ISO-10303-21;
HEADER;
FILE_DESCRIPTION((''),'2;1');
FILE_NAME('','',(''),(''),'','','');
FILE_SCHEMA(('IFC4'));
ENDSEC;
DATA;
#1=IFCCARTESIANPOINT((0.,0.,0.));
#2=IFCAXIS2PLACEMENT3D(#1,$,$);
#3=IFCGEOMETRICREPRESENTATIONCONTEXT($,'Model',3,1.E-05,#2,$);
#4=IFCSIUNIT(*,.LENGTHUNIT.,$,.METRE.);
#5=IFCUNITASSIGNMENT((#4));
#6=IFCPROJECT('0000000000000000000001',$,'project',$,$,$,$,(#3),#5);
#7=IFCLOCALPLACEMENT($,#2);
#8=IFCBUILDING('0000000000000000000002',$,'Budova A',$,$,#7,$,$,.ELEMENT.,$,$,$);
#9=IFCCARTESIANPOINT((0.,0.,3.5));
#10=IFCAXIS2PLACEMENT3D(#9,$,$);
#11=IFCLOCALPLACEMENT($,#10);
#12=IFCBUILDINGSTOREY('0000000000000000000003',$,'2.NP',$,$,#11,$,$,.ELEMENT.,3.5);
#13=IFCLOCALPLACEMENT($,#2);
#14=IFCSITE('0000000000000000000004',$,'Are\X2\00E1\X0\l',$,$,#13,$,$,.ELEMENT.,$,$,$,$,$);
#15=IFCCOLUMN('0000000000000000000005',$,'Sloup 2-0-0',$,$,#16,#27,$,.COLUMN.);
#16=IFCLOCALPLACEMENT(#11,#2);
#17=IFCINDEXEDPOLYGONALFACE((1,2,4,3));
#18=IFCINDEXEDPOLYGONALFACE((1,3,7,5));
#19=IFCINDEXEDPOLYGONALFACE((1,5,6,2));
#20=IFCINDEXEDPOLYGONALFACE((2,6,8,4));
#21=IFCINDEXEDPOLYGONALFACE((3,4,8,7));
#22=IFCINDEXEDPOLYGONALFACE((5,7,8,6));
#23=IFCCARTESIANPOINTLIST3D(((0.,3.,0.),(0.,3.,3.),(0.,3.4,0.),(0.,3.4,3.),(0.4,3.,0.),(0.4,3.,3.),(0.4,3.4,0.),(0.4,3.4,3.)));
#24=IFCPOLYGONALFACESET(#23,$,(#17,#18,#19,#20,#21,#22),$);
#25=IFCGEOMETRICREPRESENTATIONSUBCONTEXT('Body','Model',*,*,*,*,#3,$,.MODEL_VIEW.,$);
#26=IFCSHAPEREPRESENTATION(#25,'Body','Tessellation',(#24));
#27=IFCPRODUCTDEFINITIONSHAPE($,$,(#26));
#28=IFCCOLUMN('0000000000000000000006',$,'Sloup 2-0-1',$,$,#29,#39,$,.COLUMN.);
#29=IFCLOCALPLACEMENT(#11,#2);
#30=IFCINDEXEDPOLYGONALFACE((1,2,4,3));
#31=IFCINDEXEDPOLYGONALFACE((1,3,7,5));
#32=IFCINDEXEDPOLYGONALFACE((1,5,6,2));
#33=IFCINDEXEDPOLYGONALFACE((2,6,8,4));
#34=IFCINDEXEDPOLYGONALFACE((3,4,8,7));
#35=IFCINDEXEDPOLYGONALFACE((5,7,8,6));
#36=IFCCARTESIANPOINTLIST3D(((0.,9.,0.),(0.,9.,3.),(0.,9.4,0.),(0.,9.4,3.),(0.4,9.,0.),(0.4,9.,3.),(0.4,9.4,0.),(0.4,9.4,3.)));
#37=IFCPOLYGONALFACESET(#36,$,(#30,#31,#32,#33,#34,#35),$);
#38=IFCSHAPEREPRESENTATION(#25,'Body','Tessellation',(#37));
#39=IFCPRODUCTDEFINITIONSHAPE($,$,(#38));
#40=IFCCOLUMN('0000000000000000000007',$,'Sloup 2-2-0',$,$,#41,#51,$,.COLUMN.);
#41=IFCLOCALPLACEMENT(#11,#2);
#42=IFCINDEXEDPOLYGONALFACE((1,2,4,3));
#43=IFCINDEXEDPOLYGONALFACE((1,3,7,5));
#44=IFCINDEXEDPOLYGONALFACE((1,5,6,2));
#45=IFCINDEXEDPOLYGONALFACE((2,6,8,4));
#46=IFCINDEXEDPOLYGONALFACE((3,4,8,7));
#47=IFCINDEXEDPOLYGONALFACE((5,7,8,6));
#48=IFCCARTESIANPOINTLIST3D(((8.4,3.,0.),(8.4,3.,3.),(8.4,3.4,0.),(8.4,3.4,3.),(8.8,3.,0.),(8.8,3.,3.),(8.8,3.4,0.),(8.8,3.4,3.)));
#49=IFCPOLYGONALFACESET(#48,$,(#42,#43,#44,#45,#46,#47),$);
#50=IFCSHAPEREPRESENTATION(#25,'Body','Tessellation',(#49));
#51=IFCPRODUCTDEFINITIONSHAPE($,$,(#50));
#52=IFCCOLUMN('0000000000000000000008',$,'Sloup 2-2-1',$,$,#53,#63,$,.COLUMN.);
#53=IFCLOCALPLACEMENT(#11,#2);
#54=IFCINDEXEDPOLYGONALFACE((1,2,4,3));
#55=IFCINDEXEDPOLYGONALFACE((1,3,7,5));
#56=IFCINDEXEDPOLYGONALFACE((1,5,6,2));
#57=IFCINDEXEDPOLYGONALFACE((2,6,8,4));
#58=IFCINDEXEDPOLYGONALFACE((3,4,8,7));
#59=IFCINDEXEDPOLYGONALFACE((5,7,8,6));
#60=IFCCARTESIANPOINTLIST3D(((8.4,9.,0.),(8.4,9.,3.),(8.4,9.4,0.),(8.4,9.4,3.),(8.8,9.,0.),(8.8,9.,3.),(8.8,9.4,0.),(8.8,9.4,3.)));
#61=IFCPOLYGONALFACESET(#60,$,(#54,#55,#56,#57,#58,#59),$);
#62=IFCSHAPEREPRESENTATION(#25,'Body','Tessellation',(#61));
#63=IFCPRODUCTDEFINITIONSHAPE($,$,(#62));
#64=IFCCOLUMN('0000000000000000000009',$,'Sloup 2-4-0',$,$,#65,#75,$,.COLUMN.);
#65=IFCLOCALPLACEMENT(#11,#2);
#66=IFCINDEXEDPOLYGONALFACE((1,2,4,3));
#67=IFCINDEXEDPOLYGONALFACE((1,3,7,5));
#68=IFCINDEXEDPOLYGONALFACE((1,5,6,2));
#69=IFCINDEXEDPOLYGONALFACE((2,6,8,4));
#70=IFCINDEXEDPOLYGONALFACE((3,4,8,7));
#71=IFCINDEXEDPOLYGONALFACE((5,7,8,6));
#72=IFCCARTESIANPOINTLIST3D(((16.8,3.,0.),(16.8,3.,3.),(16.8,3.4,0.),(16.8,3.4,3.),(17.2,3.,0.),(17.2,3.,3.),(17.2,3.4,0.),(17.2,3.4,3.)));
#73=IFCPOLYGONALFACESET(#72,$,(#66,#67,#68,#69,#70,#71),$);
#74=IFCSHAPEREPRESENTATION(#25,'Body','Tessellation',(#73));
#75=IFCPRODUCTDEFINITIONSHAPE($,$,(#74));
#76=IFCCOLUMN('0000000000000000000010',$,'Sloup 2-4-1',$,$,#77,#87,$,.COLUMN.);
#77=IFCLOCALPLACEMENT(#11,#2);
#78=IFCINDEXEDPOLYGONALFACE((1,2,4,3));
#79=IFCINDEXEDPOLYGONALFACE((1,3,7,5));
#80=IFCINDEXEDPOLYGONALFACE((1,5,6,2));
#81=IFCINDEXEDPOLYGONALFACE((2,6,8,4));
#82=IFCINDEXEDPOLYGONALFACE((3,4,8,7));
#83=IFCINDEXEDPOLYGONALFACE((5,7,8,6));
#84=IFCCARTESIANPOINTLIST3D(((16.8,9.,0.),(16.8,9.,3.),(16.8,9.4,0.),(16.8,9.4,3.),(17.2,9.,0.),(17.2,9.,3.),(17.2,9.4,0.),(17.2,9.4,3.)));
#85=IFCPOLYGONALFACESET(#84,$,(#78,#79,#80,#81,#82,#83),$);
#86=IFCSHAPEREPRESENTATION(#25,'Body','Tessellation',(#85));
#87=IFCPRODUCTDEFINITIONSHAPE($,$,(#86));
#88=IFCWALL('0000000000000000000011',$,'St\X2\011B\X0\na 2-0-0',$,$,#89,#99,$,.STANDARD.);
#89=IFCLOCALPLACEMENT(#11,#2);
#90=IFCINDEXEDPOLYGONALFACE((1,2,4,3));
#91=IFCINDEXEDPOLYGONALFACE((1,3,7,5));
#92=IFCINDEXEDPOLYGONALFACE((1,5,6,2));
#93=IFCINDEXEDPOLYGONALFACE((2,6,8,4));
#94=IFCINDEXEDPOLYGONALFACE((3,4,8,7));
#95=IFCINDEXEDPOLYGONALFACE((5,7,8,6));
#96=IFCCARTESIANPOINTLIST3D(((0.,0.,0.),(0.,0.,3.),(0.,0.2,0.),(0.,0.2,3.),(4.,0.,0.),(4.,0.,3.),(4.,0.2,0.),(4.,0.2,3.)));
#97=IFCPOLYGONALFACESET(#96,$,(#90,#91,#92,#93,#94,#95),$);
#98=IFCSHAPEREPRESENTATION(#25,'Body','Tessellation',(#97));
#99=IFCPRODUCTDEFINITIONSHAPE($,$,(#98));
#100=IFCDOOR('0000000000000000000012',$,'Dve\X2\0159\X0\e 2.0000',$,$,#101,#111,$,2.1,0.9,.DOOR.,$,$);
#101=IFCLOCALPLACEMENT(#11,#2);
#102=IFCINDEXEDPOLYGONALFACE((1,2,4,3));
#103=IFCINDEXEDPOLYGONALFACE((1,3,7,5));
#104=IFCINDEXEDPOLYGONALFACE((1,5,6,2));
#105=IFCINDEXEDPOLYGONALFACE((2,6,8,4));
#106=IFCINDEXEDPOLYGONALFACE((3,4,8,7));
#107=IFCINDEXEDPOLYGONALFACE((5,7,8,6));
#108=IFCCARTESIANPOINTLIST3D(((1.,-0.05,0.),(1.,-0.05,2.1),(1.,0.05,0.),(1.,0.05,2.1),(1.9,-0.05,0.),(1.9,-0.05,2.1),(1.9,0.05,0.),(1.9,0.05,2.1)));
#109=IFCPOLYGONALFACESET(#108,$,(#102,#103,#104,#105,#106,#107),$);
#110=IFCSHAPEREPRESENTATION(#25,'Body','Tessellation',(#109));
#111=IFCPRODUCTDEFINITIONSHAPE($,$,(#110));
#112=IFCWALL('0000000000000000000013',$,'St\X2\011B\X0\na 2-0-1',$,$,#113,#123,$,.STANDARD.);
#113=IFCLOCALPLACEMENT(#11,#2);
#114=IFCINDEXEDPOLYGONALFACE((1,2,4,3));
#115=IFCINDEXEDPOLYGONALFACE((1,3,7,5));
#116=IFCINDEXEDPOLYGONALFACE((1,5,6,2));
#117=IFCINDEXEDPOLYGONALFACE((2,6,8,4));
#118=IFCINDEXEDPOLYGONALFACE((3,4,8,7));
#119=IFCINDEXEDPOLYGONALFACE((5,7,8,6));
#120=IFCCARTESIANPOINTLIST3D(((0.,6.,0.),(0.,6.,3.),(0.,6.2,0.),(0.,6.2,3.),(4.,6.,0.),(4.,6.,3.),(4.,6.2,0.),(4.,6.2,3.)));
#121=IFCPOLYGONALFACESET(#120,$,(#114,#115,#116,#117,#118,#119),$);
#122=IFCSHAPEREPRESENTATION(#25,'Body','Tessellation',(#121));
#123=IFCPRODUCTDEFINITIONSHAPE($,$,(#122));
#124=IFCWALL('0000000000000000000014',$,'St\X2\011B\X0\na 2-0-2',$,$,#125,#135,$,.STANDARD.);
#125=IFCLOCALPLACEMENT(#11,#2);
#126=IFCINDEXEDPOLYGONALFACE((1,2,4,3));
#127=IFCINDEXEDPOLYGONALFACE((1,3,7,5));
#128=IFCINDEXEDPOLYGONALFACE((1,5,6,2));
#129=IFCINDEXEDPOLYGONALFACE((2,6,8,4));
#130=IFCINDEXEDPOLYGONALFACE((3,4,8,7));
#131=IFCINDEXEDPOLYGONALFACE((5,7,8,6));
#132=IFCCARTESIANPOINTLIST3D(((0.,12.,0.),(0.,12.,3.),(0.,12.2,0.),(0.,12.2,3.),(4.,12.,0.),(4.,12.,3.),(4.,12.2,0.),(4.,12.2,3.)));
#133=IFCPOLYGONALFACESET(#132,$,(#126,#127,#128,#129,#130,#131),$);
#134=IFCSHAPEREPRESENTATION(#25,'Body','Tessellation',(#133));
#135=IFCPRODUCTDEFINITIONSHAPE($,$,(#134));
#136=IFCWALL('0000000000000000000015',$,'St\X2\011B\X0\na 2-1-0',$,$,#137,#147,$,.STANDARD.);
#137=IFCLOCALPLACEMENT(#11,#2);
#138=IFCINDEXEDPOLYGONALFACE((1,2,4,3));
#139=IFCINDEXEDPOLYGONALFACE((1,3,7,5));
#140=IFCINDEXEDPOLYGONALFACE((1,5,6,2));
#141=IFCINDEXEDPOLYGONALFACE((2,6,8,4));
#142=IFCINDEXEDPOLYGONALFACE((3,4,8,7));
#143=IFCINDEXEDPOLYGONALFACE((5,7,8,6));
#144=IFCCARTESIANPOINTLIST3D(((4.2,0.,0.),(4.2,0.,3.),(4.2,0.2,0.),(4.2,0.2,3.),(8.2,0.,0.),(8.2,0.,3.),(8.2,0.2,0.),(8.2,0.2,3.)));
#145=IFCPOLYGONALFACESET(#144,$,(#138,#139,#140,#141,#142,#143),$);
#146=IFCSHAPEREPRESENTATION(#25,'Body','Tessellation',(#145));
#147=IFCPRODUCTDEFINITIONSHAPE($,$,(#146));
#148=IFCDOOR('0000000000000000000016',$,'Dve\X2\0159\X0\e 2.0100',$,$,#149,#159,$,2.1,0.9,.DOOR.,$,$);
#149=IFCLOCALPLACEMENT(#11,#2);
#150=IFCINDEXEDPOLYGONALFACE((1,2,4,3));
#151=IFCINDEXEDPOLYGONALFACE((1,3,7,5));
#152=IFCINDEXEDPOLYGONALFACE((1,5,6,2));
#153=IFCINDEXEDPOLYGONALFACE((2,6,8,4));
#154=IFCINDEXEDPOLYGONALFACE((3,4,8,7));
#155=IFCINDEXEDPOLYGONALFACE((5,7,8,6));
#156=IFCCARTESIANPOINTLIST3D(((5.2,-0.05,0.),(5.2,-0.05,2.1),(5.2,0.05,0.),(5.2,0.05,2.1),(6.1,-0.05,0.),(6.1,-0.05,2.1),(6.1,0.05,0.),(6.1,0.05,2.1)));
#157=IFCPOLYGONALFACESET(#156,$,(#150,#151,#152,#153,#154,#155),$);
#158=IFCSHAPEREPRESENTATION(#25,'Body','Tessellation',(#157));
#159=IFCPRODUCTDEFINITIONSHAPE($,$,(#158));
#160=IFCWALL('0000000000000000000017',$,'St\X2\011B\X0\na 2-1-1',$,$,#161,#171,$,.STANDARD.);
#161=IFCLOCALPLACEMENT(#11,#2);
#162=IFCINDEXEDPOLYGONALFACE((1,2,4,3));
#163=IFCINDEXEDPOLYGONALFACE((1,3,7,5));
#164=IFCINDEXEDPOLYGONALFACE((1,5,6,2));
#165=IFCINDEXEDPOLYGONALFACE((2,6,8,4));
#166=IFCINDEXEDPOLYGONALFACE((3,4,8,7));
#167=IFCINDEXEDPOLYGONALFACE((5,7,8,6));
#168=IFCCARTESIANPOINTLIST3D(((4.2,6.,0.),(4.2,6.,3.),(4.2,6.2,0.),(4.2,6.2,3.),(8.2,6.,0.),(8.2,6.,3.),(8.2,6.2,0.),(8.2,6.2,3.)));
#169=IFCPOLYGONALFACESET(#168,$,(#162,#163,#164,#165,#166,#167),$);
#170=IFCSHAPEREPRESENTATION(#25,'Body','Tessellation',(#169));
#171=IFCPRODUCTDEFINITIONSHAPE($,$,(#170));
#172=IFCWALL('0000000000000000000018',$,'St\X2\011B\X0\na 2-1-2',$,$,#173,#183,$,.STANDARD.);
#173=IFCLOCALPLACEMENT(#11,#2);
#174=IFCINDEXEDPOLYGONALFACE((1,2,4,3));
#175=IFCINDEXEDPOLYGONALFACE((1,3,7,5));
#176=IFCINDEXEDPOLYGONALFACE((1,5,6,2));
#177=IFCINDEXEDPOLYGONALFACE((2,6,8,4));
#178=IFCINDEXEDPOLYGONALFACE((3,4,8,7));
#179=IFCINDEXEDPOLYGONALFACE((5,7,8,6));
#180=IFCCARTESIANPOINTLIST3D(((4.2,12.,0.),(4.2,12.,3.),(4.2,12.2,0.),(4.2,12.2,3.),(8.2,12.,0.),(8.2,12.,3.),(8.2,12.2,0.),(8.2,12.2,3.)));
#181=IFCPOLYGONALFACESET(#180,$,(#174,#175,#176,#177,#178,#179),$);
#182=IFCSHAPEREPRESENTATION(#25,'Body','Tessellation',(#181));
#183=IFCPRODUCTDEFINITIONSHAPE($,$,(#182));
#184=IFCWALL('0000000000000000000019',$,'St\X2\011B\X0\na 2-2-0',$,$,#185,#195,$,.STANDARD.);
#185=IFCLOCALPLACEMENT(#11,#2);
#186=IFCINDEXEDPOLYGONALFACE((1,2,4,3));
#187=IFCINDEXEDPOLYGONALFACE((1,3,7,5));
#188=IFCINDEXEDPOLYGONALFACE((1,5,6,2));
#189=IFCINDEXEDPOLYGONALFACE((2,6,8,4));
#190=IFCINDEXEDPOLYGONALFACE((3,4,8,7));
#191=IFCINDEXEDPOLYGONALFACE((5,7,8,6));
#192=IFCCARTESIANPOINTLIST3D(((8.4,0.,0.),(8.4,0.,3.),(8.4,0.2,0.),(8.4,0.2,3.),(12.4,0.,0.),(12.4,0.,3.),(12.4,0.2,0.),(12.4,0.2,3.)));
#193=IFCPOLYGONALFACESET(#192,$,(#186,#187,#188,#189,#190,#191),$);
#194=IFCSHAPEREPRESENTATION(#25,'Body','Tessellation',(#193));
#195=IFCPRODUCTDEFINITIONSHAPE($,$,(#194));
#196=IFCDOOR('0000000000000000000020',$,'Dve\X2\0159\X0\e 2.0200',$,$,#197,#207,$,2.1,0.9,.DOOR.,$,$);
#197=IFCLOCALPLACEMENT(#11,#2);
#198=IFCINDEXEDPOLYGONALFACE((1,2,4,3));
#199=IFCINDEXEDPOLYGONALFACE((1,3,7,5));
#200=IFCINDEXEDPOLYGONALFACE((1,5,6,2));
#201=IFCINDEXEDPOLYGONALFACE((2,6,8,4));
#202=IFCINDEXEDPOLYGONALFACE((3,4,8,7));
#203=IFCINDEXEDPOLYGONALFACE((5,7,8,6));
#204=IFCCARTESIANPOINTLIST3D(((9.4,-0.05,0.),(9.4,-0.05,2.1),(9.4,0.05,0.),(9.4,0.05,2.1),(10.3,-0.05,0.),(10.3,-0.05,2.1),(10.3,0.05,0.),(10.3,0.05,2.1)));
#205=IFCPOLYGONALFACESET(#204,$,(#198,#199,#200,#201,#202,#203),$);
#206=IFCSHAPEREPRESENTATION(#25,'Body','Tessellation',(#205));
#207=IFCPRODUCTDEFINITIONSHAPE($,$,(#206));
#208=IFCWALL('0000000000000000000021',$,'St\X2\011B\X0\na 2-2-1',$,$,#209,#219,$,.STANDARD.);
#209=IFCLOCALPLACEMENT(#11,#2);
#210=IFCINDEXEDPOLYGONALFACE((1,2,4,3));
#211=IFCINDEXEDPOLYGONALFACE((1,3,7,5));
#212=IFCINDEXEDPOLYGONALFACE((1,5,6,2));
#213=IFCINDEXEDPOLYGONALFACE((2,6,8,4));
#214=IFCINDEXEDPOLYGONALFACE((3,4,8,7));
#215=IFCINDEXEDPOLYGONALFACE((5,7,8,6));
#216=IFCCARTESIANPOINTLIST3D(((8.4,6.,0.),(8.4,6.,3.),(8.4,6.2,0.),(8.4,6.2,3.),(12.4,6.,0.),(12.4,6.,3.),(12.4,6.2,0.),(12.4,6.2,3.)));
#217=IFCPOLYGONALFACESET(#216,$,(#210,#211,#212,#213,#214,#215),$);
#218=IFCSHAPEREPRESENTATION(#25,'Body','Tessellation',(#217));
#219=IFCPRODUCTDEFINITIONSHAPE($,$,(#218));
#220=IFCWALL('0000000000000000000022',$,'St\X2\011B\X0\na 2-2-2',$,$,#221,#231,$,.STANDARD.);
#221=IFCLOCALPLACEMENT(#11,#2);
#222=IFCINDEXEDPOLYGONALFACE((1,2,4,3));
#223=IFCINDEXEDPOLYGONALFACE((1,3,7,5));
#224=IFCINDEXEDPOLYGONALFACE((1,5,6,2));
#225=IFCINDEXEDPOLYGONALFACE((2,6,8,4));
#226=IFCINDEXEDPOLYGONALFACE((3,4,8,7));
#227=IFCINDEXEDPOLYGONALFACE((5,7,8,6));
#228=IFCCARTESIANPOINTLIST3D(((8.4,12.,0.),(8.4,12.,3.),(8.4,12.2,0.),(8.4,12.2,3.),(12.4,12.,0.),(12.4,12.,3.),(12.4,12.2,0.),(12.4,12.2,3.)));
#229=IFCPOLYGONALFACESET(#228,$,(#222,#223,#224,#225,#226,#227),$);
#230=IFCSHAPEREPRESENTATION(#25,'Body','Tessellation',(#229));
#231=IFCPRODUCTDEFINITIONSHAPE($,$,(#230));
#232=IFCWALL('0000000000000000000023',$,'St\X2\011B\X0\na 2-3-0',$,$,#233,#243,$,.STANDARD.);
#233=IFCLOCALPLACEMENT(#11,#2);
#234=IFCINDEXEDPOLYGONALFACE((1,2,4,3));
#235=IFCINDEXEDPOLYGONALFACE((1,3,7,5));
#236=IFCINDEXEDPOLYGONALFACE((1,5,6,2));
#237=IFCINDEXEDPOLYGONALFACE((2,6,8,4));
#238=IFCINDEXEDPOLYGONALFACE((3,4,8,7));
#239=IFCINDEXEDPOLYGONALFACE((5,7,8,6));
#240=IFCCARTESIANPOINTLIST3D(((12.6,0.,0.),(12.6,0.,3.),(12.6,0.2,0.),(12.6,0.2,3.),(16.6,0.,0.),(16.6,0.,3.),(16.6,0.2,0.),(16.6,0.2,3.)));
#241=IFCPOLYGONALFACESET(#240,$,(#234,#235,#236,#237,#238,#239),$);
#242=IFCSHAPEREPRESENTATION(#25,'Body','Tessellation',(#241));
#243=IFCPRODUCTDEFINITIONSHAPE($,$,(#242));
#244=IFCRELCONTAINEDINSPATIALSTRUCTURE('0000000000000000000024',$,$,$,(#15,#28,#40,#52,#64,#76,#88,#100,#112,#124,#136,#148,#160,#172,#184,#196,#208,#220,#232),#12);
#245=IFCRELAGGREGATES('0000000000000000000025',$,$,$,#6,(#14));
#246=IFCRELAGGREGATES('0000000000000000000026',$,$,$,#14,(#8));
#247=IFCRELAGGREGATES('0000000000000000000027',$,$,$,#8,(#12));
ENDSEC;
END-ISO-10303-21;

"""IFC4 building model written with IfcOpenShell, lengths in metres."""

from ifc_helpers import new_model, si_unit, frame, frame_2d, origin, place, context, subcontext, project, spatial, rectangle, extrude, element, save


model = new_model("IFC4")

# Units and contexts
model_context = context("Model", 3, precision=1e-05, world=origin())
body_context = subcontext(model_context, "Body", "Model", "MODEL_VIEW")
ifc_project = project(units=[si_unit("LENGTHUNIT", "METRE")], contexts=[model_context])

# Site, building, storey
site_placement = place(None, origin())
site = spatial("IfcSite", under=ifc_project, at=site_placement, Name="Areál", CompositionType="ELEMENT")
building_placement = place(None, origin())
building = spatial("IfcBuilding", under=site, at=building_placement, Name="Budova A", CompositionType="ELEMENT")
storey_placement = place(None, frame((0.0, 0.0, 3.5)))
storey = spatial("IfcBuildingStorey", under=building, at=storey_placement, Name="2.NP", CompositionType="ELEMENT", Elevation=3.5)

# Columns
for number, where, name in (
    (1, (0.0, 3.0, 0.0), "Sloup 2-0-0"),
    (2, (0.0, 9.0, 0.0), "Sloup 2-0-1"),
    (3, (8.4, 3.0, 0.0), "Sloup 2-2-0"),
    (4, (8.4, 9.0, 0.0), "Sloup 2-2-1"),
    (5, (16.8, 3.0, 0.0), "Sloup 2-4-0"),
    (6, (16.8, 9.0, 0.0), "Sloup 2-4-1"),
):
    element("IfcColumn", number, at=place(storey_placement, frame(where)), inside=storey, Name=name, PredefinedType="COLUMN", context=body_context, shape_type="SweptSolid", body=[
        extrude(rectangle(XDim=0.4, YDim=0.4, at=frame_2d((0.2, 0.2))), origin(), (0.0, 0.0, 1.0), 3.0),
    ])

# Wall
wall_1_placement = place(storey_placement, origin())
element("IfcWall", 7, at=wall_1_placement, inside=storey, Name="Stěna 2-0-0", PredefinedType="STANDARD", context=body_context, shape_type="SweptSolid", body=[
    extrude(rectangle(XDim=4.0, YDim=0.2, at=frame_2d((2.0, 0.1))), origin(), (0.0, 0.0, 1.0), 3.0),
])

# Door
door_1_placement = place(storey_placement, frame((1.0, -0.05, 0.0)))
element("IfcDoor", 8, at=door_1_placement, inside=storey, Name="Dveře 2.0000", OverallHeight=2.1, OverallWidth=0.9, PredefinedType="DOOR", context=body_context, shape_type="SweptSolid", body=[
    extrude(rectangle(XDim=0.9, YDim=0.1, at=frame_2d((0.45, 0.05))), origin(), (0.0, 0.0, 1.0), 2.1),
])

# Walls
for number, where, name in (
    (9, (0.0, 6.0, 0.0), "Stěna 2-0-1"),
    (10, (0.0, 12.0, 0.0), "Stěna 2-0-2"),
    (11, (4.2, 0.0, 0.0), "Stěna 2-1-0"),
):
    element("IfcWall", number, at=place(storey_placement, frame(where)), inside=storey, Name=name, PredefinedType="STANDARD", context=body_context, shape_type="SweptSolid", body=[
        extrude(rectangle(XDim=4.0, YDim=0.2, at=frame_2d((2.0, 0.1))), origin(), (0.0, 0.0, 1.0), 3.0),
    ])

# Door
door_2_placement = place(storey_placement, frame((5.2, -0.05, 0.0)))
element("IfcDoor", 12, at=door_2_placement, inside=storey, Name="Dveře 2.0100", OverallHeight=2.1, OverallWidth=0.9, PredefinedType="DOOR", context=body_context, shape_type="SweptSolid", body=[
    extrude(rectangle(XDim=0.9, YDim=0.1, at=frame_2d((0.45, 0.05))), origin(), (0.0, 0.0, 1.0), 2.1),
])

# Walls
for number, where, name in (
    (13, (4.2, 6.0, 0.0), "Stěna 2-1-1"),
    (14, (4.2, 12.0, 0.0), "Stěna 2-1-2"),
    (15, (8.4, 0.0, 0.0), "Stěna 2-2-0"),
):
    element("IfcWall", number, at=place(storey_placement, frame(where)), inside=storey, Name=name, PredefinedType="STANDARD", context=body_context, shape_type="SweptSolid", body=[
        extrude(rectangle(XDim=4.0, YDim=0.2, at=frame_2d((2.0, 0.1))), origin(), (0.0, 0.0, 1.0), 3.0),
    ])

# Door
door_3_placement = place(storey_placement, frame((9.4, -0.05, 0.0)))
element("IfcDoor", 16, at=door_3_placement, inside=storey, Name="Dveře 2.0200", OverallHeight=2.1, OverallWidth=0.9, PredefinedType="DOOR", context=body_context, shape_type="SweptSolid", body=[
    extrude(rectangle(XDim=0.9, YDim=0.1, at=frame_2d((0.45, 0.05))), origin(), (0.0, 0.0, 1.0), 2.1),
])

# Walls
for number, where, name in (
    (17, (8.4, 6.0, 0.0), "Stěna 2-2-1"),
    (18, (8.4, 12.0, 0.0), "Stěna 2-2-2"),
    (19, (12.6, 0.0, 0.0), "Stěna 2-3-0"),
):
    element("IfcWall", number, at=place(storey_placement, frame(where)), inside=storey, Name=name, PredefinedType="STANDARD", context=body_context, shape_type="SweptSolid", body=[
        extrude(rectangle(XDim=4.0, YDim=0.2, at=frame_2d((2.0, 0.1))), origin(), (0.0, 0.0, 1.0), 3.0),
    ])

save(model, "model.ifc")
